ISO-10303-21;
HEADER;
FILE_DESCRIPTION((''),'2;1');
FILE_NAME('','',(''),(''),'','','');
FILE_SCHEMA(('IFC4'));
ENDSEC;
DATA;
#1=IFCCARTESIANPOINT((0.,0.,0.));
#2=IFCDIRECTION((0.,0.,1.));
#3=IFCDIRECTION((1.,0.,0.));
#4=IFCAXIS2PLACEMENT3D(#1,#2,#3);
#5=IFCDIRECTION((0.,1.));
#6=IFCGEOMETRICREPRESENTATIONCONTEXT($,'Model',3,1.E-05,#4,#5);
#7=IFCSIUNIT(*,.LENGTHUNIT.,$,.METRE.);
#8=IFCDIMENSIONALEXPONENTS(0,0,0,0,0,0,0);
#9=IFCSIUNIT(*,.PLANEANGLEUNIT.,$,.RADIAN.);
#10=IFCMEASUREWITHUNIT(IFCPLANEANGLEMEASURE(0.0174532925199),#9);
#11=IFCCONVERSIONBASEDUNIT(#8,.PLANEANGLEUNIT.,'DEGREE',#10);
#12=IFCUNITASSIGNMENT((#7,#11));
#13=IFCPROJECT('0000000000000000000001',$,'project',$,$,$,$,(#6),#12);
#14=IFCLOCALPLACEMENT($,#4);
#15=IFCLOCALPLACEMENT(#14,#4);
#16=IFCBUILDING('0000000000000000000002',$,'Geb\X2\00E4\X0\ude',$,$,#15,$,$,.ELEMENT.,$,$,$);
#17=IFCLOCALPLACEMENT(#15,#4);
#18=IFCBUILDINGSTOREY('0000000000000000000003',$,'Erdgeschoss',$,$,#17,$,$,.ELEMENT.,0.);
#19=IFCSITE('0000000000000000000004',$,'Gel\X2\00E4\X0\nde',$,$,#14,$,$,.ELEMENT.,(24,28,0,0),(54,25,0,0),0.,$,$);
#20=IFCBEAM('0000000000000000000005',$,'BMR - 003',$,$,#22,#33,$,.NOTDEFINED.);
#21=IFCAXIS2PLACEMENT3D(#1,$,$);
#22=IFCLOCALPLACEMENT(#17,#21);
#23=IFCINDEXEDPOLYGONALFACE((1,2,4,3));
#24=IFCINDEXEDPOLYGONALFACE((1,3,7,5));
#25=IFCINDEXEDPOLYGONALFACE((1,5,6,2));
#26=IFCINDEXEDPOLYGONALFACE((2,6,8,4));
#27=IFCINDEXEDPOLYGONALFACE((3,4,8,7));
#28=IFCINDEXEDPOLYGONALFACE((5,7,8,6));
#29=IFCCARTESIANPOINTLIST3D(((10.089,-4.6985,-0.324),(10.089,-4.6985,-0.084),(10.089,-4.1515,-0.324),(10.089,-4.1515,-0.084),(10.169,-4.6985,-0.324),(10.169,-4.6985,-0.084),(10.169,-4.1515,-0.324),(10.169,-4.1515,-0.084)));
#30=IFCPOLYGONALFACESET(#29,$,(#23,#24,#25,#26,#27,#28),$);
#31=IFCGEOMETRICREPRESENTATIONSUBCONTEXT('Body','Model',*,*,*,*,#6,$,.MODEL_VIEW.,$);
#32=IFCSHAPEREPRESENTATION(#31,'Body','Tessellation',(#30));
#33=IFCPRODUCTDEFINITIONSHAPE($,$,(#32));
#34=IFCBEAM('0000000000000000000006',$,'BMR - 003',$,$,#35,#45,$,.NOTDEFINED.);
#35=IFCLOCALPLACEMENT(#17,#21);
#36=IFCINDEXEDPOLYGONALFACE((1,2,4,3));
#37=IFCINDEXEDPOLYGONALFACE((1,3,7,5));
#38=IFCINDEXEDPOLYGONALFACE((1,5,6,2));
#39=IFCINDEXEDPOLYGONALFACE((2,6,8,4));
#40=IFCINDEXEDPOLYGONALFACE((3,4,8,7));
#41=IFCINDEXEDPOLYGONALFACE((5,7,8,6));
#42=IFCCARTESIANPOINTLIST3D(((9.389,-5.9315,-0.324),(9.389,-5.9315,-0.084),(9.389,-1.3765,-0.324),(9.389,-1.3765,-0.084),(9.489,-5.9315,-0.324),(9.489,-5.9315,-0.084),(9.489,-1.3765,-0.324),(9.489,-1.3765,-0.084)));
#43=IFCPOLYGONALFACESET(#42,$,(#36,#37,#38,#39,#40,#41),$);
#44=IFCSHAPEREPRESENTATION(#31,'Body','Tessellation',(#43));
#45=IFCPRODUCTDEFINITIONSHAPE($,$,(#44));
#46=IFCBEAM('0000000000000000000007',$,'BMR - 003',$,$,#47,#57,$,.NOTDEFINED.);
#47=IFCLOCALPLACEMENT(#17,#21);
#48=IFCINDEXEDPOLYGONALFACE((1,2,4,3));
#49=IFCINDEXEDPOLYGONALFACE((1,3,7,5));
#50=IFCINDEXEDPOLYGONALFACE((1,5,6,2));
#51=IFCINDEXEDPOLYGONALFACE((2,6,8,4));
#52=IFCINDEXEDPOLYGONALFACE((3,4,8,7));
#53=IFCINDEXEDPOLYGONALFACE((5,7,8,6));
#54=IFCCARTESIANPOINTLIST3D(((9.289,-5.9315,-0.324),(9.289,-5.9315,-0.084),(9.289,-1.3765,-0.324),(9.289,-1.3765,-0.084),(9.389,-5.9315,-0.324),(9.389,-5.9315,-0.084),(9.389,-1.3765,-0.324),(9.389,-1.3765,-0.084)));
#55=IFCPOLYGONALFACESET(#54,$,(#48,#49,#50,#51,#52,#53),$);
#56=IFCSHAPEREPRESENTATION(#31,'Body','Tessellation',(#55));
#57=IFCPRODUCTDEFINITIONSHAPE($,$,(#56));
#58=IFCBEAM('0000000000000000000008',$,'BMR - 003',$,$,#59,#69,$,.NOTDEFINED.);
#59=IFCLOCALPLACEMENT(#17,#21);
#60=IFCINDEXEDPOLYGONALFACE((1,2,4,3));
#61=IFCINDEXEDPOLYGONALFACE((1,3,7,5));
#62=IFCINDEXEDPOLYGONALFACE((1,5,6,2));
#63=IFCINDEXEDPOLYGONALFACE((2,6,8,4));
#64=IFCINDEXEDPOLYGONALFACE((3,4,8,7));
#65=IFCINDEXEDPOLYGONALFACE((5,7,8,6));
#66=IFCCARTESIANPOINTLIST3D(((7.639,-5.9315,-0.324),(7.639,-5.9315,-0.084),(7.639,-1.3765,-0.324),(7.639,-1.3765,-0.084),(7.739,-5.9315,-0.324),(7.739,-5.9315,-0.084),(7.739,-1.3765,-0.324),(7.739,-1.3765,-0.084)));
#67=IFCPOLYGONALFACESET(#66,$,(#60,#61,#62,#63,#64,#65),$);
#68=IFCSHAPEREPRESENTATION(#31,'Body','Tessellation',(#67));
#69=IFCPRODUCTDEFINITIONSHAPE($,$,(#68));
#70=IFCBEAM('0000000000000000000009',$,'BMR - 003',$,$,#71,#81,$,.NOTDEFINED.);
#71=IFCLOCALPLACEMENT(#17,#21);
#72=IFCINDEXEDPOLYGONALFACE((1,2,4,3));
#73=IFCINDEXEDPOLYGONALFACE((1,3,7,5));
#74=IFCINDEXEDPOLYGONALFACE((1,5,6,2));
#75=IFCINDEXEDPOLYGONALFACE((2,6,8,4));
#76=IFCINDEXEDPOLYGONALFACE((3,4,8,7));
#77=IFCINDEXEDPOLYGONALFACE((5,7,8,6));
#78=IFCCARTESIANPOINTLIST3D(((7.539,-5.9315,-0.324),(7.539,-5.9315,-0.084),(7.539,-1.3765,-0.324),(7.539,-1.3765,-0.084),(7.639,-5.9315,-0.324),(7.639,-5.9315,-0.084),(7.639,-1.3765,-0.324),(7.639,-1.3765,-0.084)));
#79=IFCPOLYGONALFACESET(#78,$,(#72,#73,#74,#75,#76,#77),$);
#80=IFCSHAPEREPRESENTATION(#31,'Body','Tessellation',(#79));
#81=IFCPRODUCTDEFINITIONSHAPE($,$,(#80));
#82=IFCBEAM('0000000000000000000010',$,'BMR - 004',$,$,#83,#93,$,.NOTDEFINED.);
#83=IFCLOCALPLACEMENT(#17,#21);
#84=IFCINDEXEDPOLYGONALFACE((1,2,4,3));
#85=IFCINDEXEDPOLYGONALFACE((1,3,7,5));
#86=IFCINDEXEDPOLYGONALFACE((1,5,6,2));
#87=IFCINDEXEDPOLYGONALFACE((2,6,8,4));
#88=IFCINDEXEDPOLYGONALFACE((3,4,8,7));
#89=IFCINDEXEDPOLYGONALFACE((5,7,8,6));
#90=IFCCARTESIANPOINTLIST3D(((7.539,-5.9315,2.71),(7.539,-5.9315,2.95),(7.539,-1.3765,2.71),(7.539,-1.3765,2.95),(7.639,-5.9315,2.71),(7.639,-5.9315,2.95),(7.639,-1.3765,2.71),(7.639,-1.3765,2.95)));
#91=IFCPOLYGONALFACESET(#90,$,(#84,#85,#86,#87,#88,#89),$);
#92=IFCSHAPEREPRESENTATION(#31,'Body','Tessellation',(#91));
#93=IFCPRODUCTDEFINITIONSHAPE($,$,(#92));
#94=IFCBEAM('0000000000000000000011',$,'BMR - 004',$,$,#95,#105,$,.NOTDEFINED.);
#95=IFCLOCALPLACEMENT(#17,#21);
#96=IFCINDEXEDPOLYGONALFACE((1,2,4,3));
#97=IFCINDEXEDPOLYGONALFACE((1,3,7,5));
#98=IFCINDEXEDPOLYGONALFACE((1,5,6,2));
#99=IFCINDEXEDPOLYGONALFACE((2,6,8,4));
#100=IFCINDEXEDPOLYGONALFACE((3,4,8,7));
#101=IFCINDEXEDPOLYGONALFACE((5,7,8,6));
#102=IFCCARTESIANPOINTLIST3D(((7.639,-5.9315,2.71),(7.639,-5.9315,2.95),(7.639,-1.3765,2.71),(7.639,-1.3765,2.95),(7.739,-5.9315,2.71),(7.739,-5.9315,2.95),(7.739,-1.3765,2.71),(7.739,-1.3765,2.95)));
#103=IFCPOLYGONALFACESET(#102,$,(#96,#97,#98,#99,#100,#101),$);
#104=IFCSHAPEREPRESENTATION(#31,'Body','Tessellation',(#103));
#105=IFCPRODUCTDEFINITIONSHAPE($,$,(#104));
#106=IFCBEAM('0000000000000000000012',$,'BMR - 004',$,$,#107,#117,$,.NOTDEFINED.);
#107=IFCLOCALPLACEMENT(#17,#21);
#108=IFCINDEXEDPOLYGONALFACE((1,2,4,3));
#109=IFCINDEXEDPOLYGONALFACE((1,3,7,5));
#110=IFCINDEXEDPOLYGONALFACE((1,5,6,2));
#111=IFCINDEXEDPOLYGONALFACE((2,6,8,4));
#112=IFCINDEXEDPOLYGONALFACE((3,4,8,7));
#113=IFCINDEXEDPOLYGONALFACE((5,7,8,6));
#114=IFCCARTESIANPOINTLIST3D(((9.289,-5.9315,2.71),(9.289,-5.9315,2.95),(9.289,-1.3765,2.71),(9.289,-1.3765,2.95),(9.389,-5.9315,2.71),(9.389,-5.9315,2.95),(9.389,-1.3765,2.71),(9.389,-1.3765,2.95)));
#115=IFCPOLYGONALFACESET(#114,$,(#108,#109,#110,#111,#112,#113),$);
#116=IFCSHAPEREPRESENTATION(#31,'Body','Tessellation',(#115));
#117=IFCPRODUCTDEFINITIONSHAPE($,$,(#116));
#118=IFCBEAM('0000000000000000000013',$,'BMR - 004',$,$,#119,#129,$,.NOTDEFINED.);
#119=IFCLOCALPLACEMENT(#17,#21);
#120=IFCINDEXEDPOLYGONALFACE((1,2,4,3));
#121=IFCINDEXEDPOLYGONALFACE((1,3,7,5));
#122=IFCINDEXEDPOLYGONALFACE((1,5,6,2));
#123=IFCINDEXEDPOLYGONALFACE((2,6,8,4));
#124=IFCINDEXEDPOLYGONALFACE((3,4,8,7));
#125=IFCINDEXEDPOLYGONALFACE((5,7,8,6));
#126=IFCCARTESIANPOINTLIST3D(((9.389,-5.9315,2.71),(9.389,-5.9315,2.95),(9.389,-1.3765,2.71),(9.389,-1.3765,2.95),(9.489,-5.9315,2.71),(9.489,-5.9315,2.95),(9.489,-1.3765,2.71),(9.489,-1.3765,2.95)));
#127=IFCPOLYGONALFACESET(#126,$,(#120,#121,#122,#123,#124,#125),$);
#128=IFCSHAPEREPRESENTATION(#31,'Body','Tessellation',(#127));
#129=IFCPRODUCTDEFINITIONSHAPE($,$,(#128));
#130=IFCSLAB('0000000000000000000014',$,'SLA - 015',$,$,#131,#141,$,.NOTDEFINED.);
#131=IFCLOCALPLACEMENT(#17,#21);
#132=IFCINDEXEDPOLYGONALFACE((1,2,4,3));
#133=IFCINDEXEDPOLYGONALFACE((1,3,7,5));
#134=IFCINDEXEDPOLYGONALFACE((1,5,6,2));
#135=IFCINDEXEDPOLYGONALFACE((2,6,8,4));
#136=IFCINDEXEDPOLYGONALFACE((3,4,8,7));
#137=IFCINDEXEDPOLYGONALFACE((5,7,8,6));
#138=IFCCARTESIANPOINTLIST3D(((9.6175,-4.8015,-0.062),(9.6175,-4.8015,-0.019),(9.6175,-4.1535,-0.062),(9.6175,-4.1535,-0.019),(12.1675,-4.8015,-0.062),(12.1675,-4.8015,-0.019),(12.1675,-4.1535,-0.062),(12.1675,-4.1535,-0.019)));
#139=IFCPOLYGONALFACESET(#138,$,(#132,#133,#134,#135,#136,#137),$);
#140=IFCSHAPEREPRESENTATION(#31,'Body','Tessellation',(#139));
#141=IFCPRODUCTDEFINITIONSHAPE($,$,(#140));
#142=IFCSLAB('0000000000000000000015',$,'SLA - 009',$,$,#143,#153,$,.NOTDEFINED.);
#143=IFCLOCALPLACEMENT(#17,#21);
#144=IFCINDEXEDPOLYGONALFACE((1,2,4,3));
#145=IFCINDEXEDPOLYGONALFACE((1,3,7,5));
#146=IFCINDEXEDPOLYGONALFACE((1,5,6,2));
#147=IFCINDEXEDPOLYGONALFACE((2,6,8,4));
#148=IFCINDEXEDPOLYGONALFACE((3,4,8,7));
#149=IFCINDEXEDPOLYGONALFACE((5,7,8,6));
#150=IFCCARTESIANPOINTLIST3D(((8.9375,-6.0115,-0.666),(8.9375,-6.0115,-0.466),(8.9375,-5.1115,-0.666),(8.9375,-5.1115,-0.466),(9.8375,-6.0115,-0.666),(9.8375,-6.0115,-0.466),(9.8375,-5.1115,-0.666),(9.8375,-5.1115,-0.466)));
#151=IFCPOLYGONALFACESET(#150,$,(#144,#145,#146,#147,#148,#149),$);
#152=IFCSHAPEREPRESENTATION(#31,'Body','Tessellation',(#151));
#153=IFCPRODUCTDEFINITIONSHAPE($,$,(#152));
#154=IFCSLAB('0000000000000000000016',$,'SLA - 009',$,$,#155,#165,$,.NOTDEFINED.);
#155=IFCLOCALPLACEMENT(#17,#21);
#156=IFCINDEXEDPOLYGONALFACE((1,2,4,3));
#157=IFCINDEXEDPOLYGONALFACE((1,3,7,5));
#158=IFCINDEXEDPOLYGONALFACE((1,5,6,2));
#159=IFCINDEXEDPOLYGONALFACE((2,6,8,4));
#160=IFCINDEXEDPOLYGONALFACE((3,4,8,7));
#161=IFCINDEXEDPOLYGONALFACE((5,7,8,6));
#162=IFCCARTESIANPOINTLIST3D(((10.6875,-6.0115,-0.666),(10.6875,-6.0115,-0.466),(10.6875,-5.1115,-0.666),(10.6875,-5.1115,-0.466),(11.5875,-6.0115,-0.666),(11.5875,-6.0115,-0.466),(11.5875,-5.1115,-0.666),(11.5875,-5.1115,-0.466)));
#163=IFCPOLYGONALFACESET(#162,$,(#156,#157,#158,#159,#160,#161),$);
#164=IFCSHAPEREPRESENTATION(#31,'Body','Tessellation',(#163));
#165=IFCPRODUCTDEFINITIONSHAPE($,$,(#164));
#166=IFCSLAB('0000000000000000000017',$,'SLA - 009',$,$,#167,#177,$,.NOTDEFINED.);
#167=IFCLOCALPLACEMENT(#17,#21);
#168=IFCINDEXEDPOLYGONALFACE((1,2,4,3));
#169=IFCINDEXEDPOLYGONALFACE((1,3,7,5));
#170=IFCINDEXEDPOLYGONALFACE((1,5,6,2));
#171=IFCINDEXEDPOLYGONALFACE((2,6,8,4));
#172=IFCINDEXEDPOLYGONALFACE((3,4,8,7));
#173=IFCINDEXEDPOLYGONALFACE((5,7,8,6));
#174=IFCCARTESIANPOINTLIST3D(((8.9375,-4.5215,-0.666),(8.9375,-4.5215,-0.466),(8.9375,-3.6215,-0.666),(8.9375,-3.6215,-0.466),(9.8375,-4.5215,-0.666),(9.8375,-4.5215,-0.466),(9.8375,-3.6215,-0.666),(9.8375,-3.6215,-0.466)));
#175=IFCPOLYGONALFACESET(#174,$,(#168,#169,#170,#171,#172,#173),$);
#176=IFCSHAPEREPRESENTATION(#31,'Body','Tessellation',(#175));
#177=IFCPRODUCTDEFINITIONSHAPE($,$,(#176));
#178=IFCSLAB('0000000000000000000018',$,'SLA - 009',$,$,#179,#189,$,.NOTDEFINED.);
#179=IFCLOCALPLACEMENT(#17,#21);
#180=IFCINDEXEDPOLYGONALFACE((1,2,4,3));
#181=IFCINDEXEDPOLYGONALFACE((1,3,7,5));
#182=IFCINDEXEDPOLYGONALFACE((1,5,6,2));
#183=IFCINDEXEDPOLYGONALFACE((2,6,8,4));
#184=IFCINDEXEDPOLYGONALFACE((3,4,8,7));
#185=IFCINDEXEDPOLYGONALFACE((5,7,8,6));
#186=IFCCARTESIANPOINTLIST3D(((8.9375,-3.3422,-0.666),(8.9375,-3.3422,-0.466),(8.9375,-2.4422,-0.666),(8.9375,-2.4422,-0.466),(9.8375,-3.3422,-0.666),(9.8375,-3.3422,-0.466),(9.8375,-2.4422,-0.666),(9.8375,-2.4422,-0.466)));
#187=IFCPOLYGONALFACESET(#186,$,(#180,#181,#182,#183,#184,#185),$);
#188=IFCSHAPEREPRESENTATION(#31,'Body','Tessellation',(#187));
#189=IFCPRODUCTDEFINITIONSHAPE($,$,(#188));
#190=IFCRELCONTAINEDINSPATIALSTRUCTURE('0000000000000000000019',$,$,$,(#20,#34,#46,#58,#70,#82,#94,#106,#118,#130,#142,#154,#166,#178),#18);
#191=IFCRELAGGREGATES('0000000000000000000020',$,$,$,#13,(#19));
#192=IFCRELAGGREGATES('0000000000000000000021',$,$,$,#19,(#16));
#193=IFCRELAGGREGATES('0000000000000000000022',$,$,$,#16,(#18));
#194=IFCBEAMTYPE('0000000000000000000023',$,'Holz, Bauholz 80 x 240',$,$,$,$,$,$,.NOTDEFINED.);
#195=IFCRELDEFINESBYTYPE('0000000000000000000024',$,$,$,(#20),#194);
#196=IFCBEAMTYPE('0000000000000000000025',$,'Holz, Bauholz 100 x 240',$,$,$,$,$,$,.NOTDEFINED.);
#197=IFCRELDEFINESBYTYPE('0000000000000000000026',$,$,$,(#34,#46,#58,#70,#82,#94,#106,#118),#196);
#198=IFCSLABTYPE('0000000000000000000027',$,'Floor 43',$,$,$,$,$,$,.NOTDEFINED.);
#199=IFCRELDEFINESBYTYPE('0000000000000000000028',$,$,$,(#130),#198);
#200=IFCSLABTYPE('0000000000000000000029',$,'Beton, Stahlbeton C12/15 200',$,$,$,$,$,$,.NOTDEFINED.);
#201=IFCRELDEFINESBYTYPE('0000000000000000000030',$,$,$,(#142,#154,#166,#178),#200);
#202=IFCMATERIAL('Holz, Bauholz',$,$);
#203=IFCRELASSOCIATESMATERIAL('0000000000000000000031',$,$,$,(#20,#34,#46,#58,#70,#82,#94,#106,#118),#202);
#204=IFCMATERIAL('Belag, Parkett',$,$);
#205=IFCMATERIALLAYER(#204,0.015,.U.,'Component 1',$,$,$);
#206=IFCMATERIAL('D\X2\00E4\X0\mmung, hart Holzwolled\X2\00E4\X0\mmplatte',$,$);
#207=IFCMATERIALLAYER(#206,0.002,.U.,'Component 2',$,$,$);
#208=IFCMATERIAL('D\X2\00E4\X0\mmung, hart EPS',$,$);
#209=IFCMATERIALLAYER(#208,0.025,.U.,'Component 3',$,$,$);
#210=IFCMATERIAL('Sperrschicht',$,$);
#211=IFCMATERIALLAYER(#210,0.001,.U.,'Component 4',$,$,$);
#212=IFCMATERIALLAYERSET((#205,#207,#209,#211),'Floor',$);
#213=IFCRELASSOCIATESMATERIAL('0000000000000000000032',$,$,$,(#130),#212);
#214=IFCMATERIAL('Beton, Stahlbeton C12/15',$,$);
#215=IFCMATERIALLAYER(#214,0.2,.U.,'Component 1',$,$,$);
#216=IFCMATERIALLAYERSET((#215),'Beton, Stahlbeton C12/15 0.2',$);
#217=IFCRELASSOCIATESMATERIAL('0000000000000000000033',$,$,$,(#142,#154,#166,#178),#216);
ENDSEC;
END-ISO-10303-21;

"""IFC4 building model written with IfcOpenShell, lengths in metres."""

from ifc_helpers import new_model, entity, si_unit, converted_unit, direction, frame, frame_2d, origin_with_axes, place, context, subcontext, project, spatial, line, indexed_curve, rectangle, outline, extrude, material, layer, layer_set, layer_usage, type_object, element, save


model = new_model("IFC4")

# Units and contexts
model_context = context("Model", 3, precision=1e-05, world=origin_with_axes(), true_north=direction((0.0, 1.0)))
body_context = subcontext(model_context, "Body", "Model", "MODEL_VIEW")
ifc_project = project(units=[si_unit("LENGTHUNIT", "METRE"), converted_unit("PLANEANGLEUNIT", "DEGREE", entity("IfcPlaneAngleMeasure", 0.0174532925199), si_unit("PLANEANGLEUNIT", "RADIAN"), dimensions=[0, 0, 0, 0, 0, 0, 0])], contexts=[model_context])

# Site, building, storey
site_placement = place(None, origin_with_axes())
site = spatial("IfcSite", under=ifc_project, at=site_placement, Name="Gelände", CompositionType="ELEMENT", RefLatitude=(24, 28, 0, 0), RefLongitude=(54, 25, 0, 0), RefElevation=0.0)
building_placement = place(site_placement, origin_with_axes())
building = spatial("IfcBuilding", under=site, at=building_placement, Name="Gebäude", CompositionType="ELEMENT")
storey_placement = place(building_placement, origin_with_axes())
storey = spatial("IfcBuildingStorey", under=building, at=storey_placement, Name="Erdgeschoss", CompositionType="ELEMENT", Elevation=0.0)

# Shared definitions
ifc_material_1 = material(Name="Holz, Bauholz")

# Beams
beam_type_1 = type_object("IfcBeamType", Name="Holz, Bauholz 80 x 240", PredefinedType="NOTDEFINED")
beam_1_placement = place(storey_placement, frame((10.129, -4.6985, -0.084), z_axis=(0.0, 0.0, 1.0), x_axis=(1.0, 0.0, 0.0)))
element("IfcBeam", 1, at=beam_1_placement, inside=storey, type_object=beam_type_1, material=ifc_material_1, Name="BMR - 003", PredefinedType="NOTDEFINED", context=body_context, shape_type="SweptSolid", body=[
    extrude(rectangle(XDim=0.24, YDim=0.08, at=frame_2d((-0.12, 0.0), x_axis=(1.0, 0.0))), frame((0.0, 0.0, 0.0), z_axis=(0.0, 1.0, 0.0), x_axis=(0.0, 0.0, 1.0)), (0.0, 0.0, 1.0), 0.547),
])
beam_type_2 = type_object("IfcBeamType", Name="Holz, Bauholz 100 x 240", PredefinedType="NOTDEFINED")
for number, where, z_axis, x_axis, name in (
    (2, (9.439, -5.9315, -0.084), (0.0, 0.0, 1.0), (1.0, 0.0, 0.0), "BMR - 003"),
    (3, (9.339, -5.9315, -0.084), (0.0, 0.0, 1.0), (1.0, 0.0, 0.0), "BMR - 003"),
    (4, (7.689, -5.9315, -0.084), (0.0, 0.0, 1.0), (1.0, 0.0, 0.0), "BMR - 003"),
    (5, (7.589, -5.9315, -0.084), (0.0, 0.0, 1.0), (1.0, 0.0, 0.0), "BMR - 003"),
):
    element("IfcBeam", number, at=place(storey_placement, frame(where, z_axis=z_axis, x_axis=x_axis)), inside=storey, type_object=beam_type_2, material=ifc_material_1, Name=name, PredefinedType="NOTDEFINED", context=body_context, shape_type="SweptSolid", body=[
        extrude(rectangle(XDim=0.24, YDim=0.1, at=frame_2d((-0.12, 0.0), x_axis=(1.0, 0.0))), frame((0.0, 0.0, 0.0), z_axis=(0.0, 1.0, 0.0), x_axis=(0.0, 0.0, 1.0)), (0.0, 0.0, 1.0), 4.555),
    ])
for number, where, z_axis, x_axis, name in (
    (6, (7.589, -5.9315, 2.95), (0.0, 0.0, 1.0), (1.0, 0.0, 0.0), "BMR - 004"),
    (7, (7.689, -5.9315, 2.95), (0.0, 0.0, 1.0), (1.0, 0.0, 0.0), "BMR - 004"),
    (8, (9.339, -5.9315, 2.95), (0.0, 0.0, 1.0), (1.0, 0.0, 0.0), "BMR - 004"),
    (9, (9.439, -5.9315, 2.95), (0.0, 0.0, 1.0), (1.0, 0.0, 0.0), "BMR - 004"),
):
    element("IfcBeam", number, at=place(storey_placement, frame(where, z_axis=z_axis, x_axis=x_axis)), inside=storey, type_object=beam_type_2, material=ifc_material_1, Name=name, PredefinedType="NOTDEFINED", context=body_context, shape_type="SweptSolid", body=[
        extrude(rectangle(XDim=0.24, YDim=0.1, at=frame_2d((-0.12, 0.0), x_axis=(1.0, 0.0))), frame((0.0, 0.0, 0.0), z_axis=(0.0, 1.0, 0.0), x_axis=(0.0, 0.0, 1.0)), (0.0, 0.0, 1.0), 4.555),
    ])

# Slabs
ifc_material_2 = material(Name="Belag, Parkett")
ifc_layer_1 = layer(ifc_material_2, 0.015, ventilated="UNKNOWN", Name="Component 1")
ifc_material_3 = material(Name="Dämmung, hart Holzwolledämmplatte")
ifc_layer_2 = layer(ifc_material_3, 0.002, ventilated="UNKNOWN", Name="Component 2")
ifc_material_4 = material(Name="Dämmung, hart EPS")
ifc_layer_3 = layer(ifc_material_4, 0.025, ventilated="UNKNOWN", Name="Component 3")
ifc_material_5 = material(Name="Sperrschicht")
ifc_layer_4 = layer(ifc_material_5, 0.001, ventilated="UNKNOWN", Name="Component 4")
ifc_layer_set_1 = layer_set([ifc_layer_1, ifc_layer_2, ifc_layer_3, ifc_layer_4], Name="Floor")
ifc_layer_usage_1 = layer_usage(ifc_layer_set_1, "AXIS3", "NEGATIVE", 0.043)
slab_type_1 = type_object("IfcSlabType", Name="Floor 43", PredefinedType="NOTDEFINED")
slab_1_placement = place(storey_placement, frame((9.6175, -4.1535, -0.019), z_axis=(0.0, 0.0, 1.0), x_axis=(1.0, 0.0, 0.0)))
element("IfcSlab", 10, at=slab_1_placement, inside=storey, type_object=slab_type_1, material=ifc_layer_usage_1, Name="SLA - 015", PredefinedType="NOTDEFINED", context=body_context, shape_type="SweptSolid", body=[
    extrude(outline(indexed_curve([(0.0, 0.0), (0.0, -0.648), (2.55, -0.648), (2.55, 0.0)], segments=[line(1, 2, 3, 4, 1)])), frame((0.0, 0.0, -0.043), z_axis=(0.0, 0.0, 1.0), x_axis=(1.0, 0.0, 0.0)), (0.0, 0.0, 1.0), 0.043),
])
ifc_material_6 = material(Name="Beton, Stahlbeton C12/15")
ifc_layer_5 = layer(ifc_material_6, 0.2, ventilated="UNKNOWN", Name="Component 1")
ifc_layer_set_2 = layer_set([ifc_layer_5], Name="Beton, Stahlbeton C12/15 0.2")
ifc_layer_usage_2 = layer_usage(ifc_layer_set_2, "AXIS3", "NEGATIVE", 0.2)
slab_type_2 = type_object("IfcSlabType", Name="Beton, Stahlbeton C12/15 200", PredefinedType="NOTDEFINED")
slab_2_placement = place(storey_placement, frame((8.9375, -6.0115, -0.466), z_axis=(0.0, 0.0, 1.0), x_axis=(1.0, 0.0, 0.0)))
element("IfcSlab", 11, at=slab_2_placement, inside=storey, type_object=slab_type_2, material=ifc_layer_usage_2, Name="SLA - 009", PredefinedType="NOTDEFINED", context=body_context, shape_type="SweptSolid", body=[
    extrude(outline(indexed_curve([(0.0, 0.0), (0.9, 0.0), (0.9, 0.9), (0.0, 0.9)], segments=[line(1, 2, 3, 4, 1)])), frame((0.0, 0.0, -0.2), z_axis=(0.0, 0.0, 1.0), x_axis=(1.0, 0.0, 0.0)), (0.0, 0.0, 1.0), 0.2),
])
ifc_layer_usage_3 = layer_usage(ifc_layer_set_2, "AXIS3", "NEGATIVE", 0.2)
slab_3_placement = place(storey_placement, frame((10.6875, -6.0115, -0.466), z_axis=(0.0, 0.0, 1.0), x_axis=(1.0, 0.0, 0.0)))
element("IfcSlab", 12, at=slab_3_placement, inside=storey, type_object=slab_type_2, material=ifc_layer_usage_3, Name="SLA - 009", PredefinedType="NOTDEFINED", context=body_context, shape_type="SweptSolid", body=[
    extrude(outline(indexed_curve([(0.0, 0.0), (0.9, 0.0), (0.9, 0.9), (0.0, 0.9)], segments=[line(1, 2, 3, 4, 1)])), frame((0.0, 0.0, -0.2), z_axis=(0.0, 0.0, 1.0), x_axis=(1.0, 0.0, 0.0)), (0.0, 0.0, 1.0), 0.2),
])
ifc_layer_usage_4 = layer_usage(ifc_layer_set_2, "AXIS3", "NEGATIVE", 0.2)
slab_4_placement = place(storey_placement, frame((8.9375, -4.5215, -0.466), z_axis=(0.0, 0.0, 1.0), x_axis=(1.0, 0.0, 0.0)))
element("IfcSlab", 13, at=slab_4_placement, inside=storey, type_object=slab_type_2, material=ifc_layer_usage_4, Name="SLA - 009", PredefinedType="NOTDEFINED", context=body_context, shape_type="SweptSolid", body=[
    extrude(outline(indexed_curve([(0.0, 0.0), (0.9, 0.0), (0.9, 0.9), (0.0, 0.9)], segments=[line(1, 2, 3, 4, 1)])), frame((0.0, 0.0, -0.2), z_axis=(0.0, 0.0, 1.0), x_axis=(1.0, 0.0, 0.0)), (0.0, 0.0, 1.0), 0.2),
])
ifc_layer_usage_5 = layer_usage(ifc_layer_set_2, "AXIS3", "NEGATIVE", 0.2)
slab_5_placement = place(storey_placement, frame((8.9375, -3.3422, -0.466), z_axis=(0.0, 0.0, 1.0), x_axis=(1.0, 0.0, 0.0)))
element("IfcSlab", 14, at=slab_5_placement, inside=storey, type_object=slab_type_2, material=ifc_layer_usage_5, Name="SLA - 009", PredefinedType="NOTDEFINED", context=body_context, shape_type="SweptSolid", body=[
    extrude(outline(indexed_curve([(0.0, 0.0), (0.9, 0.0), (0.9, 0.9), (0.0, 0.9)], segments=[line(1, 2, 3, 4, 1)])), frame((0.0, 0.0, -0.2), z_axis=(0.0, 0.0, 1.0), x_axis=(1.0, 0.0, 0.0)), (0.0, 0.0, 1.0), 0.2),
])

save(model, "model.ifc")
